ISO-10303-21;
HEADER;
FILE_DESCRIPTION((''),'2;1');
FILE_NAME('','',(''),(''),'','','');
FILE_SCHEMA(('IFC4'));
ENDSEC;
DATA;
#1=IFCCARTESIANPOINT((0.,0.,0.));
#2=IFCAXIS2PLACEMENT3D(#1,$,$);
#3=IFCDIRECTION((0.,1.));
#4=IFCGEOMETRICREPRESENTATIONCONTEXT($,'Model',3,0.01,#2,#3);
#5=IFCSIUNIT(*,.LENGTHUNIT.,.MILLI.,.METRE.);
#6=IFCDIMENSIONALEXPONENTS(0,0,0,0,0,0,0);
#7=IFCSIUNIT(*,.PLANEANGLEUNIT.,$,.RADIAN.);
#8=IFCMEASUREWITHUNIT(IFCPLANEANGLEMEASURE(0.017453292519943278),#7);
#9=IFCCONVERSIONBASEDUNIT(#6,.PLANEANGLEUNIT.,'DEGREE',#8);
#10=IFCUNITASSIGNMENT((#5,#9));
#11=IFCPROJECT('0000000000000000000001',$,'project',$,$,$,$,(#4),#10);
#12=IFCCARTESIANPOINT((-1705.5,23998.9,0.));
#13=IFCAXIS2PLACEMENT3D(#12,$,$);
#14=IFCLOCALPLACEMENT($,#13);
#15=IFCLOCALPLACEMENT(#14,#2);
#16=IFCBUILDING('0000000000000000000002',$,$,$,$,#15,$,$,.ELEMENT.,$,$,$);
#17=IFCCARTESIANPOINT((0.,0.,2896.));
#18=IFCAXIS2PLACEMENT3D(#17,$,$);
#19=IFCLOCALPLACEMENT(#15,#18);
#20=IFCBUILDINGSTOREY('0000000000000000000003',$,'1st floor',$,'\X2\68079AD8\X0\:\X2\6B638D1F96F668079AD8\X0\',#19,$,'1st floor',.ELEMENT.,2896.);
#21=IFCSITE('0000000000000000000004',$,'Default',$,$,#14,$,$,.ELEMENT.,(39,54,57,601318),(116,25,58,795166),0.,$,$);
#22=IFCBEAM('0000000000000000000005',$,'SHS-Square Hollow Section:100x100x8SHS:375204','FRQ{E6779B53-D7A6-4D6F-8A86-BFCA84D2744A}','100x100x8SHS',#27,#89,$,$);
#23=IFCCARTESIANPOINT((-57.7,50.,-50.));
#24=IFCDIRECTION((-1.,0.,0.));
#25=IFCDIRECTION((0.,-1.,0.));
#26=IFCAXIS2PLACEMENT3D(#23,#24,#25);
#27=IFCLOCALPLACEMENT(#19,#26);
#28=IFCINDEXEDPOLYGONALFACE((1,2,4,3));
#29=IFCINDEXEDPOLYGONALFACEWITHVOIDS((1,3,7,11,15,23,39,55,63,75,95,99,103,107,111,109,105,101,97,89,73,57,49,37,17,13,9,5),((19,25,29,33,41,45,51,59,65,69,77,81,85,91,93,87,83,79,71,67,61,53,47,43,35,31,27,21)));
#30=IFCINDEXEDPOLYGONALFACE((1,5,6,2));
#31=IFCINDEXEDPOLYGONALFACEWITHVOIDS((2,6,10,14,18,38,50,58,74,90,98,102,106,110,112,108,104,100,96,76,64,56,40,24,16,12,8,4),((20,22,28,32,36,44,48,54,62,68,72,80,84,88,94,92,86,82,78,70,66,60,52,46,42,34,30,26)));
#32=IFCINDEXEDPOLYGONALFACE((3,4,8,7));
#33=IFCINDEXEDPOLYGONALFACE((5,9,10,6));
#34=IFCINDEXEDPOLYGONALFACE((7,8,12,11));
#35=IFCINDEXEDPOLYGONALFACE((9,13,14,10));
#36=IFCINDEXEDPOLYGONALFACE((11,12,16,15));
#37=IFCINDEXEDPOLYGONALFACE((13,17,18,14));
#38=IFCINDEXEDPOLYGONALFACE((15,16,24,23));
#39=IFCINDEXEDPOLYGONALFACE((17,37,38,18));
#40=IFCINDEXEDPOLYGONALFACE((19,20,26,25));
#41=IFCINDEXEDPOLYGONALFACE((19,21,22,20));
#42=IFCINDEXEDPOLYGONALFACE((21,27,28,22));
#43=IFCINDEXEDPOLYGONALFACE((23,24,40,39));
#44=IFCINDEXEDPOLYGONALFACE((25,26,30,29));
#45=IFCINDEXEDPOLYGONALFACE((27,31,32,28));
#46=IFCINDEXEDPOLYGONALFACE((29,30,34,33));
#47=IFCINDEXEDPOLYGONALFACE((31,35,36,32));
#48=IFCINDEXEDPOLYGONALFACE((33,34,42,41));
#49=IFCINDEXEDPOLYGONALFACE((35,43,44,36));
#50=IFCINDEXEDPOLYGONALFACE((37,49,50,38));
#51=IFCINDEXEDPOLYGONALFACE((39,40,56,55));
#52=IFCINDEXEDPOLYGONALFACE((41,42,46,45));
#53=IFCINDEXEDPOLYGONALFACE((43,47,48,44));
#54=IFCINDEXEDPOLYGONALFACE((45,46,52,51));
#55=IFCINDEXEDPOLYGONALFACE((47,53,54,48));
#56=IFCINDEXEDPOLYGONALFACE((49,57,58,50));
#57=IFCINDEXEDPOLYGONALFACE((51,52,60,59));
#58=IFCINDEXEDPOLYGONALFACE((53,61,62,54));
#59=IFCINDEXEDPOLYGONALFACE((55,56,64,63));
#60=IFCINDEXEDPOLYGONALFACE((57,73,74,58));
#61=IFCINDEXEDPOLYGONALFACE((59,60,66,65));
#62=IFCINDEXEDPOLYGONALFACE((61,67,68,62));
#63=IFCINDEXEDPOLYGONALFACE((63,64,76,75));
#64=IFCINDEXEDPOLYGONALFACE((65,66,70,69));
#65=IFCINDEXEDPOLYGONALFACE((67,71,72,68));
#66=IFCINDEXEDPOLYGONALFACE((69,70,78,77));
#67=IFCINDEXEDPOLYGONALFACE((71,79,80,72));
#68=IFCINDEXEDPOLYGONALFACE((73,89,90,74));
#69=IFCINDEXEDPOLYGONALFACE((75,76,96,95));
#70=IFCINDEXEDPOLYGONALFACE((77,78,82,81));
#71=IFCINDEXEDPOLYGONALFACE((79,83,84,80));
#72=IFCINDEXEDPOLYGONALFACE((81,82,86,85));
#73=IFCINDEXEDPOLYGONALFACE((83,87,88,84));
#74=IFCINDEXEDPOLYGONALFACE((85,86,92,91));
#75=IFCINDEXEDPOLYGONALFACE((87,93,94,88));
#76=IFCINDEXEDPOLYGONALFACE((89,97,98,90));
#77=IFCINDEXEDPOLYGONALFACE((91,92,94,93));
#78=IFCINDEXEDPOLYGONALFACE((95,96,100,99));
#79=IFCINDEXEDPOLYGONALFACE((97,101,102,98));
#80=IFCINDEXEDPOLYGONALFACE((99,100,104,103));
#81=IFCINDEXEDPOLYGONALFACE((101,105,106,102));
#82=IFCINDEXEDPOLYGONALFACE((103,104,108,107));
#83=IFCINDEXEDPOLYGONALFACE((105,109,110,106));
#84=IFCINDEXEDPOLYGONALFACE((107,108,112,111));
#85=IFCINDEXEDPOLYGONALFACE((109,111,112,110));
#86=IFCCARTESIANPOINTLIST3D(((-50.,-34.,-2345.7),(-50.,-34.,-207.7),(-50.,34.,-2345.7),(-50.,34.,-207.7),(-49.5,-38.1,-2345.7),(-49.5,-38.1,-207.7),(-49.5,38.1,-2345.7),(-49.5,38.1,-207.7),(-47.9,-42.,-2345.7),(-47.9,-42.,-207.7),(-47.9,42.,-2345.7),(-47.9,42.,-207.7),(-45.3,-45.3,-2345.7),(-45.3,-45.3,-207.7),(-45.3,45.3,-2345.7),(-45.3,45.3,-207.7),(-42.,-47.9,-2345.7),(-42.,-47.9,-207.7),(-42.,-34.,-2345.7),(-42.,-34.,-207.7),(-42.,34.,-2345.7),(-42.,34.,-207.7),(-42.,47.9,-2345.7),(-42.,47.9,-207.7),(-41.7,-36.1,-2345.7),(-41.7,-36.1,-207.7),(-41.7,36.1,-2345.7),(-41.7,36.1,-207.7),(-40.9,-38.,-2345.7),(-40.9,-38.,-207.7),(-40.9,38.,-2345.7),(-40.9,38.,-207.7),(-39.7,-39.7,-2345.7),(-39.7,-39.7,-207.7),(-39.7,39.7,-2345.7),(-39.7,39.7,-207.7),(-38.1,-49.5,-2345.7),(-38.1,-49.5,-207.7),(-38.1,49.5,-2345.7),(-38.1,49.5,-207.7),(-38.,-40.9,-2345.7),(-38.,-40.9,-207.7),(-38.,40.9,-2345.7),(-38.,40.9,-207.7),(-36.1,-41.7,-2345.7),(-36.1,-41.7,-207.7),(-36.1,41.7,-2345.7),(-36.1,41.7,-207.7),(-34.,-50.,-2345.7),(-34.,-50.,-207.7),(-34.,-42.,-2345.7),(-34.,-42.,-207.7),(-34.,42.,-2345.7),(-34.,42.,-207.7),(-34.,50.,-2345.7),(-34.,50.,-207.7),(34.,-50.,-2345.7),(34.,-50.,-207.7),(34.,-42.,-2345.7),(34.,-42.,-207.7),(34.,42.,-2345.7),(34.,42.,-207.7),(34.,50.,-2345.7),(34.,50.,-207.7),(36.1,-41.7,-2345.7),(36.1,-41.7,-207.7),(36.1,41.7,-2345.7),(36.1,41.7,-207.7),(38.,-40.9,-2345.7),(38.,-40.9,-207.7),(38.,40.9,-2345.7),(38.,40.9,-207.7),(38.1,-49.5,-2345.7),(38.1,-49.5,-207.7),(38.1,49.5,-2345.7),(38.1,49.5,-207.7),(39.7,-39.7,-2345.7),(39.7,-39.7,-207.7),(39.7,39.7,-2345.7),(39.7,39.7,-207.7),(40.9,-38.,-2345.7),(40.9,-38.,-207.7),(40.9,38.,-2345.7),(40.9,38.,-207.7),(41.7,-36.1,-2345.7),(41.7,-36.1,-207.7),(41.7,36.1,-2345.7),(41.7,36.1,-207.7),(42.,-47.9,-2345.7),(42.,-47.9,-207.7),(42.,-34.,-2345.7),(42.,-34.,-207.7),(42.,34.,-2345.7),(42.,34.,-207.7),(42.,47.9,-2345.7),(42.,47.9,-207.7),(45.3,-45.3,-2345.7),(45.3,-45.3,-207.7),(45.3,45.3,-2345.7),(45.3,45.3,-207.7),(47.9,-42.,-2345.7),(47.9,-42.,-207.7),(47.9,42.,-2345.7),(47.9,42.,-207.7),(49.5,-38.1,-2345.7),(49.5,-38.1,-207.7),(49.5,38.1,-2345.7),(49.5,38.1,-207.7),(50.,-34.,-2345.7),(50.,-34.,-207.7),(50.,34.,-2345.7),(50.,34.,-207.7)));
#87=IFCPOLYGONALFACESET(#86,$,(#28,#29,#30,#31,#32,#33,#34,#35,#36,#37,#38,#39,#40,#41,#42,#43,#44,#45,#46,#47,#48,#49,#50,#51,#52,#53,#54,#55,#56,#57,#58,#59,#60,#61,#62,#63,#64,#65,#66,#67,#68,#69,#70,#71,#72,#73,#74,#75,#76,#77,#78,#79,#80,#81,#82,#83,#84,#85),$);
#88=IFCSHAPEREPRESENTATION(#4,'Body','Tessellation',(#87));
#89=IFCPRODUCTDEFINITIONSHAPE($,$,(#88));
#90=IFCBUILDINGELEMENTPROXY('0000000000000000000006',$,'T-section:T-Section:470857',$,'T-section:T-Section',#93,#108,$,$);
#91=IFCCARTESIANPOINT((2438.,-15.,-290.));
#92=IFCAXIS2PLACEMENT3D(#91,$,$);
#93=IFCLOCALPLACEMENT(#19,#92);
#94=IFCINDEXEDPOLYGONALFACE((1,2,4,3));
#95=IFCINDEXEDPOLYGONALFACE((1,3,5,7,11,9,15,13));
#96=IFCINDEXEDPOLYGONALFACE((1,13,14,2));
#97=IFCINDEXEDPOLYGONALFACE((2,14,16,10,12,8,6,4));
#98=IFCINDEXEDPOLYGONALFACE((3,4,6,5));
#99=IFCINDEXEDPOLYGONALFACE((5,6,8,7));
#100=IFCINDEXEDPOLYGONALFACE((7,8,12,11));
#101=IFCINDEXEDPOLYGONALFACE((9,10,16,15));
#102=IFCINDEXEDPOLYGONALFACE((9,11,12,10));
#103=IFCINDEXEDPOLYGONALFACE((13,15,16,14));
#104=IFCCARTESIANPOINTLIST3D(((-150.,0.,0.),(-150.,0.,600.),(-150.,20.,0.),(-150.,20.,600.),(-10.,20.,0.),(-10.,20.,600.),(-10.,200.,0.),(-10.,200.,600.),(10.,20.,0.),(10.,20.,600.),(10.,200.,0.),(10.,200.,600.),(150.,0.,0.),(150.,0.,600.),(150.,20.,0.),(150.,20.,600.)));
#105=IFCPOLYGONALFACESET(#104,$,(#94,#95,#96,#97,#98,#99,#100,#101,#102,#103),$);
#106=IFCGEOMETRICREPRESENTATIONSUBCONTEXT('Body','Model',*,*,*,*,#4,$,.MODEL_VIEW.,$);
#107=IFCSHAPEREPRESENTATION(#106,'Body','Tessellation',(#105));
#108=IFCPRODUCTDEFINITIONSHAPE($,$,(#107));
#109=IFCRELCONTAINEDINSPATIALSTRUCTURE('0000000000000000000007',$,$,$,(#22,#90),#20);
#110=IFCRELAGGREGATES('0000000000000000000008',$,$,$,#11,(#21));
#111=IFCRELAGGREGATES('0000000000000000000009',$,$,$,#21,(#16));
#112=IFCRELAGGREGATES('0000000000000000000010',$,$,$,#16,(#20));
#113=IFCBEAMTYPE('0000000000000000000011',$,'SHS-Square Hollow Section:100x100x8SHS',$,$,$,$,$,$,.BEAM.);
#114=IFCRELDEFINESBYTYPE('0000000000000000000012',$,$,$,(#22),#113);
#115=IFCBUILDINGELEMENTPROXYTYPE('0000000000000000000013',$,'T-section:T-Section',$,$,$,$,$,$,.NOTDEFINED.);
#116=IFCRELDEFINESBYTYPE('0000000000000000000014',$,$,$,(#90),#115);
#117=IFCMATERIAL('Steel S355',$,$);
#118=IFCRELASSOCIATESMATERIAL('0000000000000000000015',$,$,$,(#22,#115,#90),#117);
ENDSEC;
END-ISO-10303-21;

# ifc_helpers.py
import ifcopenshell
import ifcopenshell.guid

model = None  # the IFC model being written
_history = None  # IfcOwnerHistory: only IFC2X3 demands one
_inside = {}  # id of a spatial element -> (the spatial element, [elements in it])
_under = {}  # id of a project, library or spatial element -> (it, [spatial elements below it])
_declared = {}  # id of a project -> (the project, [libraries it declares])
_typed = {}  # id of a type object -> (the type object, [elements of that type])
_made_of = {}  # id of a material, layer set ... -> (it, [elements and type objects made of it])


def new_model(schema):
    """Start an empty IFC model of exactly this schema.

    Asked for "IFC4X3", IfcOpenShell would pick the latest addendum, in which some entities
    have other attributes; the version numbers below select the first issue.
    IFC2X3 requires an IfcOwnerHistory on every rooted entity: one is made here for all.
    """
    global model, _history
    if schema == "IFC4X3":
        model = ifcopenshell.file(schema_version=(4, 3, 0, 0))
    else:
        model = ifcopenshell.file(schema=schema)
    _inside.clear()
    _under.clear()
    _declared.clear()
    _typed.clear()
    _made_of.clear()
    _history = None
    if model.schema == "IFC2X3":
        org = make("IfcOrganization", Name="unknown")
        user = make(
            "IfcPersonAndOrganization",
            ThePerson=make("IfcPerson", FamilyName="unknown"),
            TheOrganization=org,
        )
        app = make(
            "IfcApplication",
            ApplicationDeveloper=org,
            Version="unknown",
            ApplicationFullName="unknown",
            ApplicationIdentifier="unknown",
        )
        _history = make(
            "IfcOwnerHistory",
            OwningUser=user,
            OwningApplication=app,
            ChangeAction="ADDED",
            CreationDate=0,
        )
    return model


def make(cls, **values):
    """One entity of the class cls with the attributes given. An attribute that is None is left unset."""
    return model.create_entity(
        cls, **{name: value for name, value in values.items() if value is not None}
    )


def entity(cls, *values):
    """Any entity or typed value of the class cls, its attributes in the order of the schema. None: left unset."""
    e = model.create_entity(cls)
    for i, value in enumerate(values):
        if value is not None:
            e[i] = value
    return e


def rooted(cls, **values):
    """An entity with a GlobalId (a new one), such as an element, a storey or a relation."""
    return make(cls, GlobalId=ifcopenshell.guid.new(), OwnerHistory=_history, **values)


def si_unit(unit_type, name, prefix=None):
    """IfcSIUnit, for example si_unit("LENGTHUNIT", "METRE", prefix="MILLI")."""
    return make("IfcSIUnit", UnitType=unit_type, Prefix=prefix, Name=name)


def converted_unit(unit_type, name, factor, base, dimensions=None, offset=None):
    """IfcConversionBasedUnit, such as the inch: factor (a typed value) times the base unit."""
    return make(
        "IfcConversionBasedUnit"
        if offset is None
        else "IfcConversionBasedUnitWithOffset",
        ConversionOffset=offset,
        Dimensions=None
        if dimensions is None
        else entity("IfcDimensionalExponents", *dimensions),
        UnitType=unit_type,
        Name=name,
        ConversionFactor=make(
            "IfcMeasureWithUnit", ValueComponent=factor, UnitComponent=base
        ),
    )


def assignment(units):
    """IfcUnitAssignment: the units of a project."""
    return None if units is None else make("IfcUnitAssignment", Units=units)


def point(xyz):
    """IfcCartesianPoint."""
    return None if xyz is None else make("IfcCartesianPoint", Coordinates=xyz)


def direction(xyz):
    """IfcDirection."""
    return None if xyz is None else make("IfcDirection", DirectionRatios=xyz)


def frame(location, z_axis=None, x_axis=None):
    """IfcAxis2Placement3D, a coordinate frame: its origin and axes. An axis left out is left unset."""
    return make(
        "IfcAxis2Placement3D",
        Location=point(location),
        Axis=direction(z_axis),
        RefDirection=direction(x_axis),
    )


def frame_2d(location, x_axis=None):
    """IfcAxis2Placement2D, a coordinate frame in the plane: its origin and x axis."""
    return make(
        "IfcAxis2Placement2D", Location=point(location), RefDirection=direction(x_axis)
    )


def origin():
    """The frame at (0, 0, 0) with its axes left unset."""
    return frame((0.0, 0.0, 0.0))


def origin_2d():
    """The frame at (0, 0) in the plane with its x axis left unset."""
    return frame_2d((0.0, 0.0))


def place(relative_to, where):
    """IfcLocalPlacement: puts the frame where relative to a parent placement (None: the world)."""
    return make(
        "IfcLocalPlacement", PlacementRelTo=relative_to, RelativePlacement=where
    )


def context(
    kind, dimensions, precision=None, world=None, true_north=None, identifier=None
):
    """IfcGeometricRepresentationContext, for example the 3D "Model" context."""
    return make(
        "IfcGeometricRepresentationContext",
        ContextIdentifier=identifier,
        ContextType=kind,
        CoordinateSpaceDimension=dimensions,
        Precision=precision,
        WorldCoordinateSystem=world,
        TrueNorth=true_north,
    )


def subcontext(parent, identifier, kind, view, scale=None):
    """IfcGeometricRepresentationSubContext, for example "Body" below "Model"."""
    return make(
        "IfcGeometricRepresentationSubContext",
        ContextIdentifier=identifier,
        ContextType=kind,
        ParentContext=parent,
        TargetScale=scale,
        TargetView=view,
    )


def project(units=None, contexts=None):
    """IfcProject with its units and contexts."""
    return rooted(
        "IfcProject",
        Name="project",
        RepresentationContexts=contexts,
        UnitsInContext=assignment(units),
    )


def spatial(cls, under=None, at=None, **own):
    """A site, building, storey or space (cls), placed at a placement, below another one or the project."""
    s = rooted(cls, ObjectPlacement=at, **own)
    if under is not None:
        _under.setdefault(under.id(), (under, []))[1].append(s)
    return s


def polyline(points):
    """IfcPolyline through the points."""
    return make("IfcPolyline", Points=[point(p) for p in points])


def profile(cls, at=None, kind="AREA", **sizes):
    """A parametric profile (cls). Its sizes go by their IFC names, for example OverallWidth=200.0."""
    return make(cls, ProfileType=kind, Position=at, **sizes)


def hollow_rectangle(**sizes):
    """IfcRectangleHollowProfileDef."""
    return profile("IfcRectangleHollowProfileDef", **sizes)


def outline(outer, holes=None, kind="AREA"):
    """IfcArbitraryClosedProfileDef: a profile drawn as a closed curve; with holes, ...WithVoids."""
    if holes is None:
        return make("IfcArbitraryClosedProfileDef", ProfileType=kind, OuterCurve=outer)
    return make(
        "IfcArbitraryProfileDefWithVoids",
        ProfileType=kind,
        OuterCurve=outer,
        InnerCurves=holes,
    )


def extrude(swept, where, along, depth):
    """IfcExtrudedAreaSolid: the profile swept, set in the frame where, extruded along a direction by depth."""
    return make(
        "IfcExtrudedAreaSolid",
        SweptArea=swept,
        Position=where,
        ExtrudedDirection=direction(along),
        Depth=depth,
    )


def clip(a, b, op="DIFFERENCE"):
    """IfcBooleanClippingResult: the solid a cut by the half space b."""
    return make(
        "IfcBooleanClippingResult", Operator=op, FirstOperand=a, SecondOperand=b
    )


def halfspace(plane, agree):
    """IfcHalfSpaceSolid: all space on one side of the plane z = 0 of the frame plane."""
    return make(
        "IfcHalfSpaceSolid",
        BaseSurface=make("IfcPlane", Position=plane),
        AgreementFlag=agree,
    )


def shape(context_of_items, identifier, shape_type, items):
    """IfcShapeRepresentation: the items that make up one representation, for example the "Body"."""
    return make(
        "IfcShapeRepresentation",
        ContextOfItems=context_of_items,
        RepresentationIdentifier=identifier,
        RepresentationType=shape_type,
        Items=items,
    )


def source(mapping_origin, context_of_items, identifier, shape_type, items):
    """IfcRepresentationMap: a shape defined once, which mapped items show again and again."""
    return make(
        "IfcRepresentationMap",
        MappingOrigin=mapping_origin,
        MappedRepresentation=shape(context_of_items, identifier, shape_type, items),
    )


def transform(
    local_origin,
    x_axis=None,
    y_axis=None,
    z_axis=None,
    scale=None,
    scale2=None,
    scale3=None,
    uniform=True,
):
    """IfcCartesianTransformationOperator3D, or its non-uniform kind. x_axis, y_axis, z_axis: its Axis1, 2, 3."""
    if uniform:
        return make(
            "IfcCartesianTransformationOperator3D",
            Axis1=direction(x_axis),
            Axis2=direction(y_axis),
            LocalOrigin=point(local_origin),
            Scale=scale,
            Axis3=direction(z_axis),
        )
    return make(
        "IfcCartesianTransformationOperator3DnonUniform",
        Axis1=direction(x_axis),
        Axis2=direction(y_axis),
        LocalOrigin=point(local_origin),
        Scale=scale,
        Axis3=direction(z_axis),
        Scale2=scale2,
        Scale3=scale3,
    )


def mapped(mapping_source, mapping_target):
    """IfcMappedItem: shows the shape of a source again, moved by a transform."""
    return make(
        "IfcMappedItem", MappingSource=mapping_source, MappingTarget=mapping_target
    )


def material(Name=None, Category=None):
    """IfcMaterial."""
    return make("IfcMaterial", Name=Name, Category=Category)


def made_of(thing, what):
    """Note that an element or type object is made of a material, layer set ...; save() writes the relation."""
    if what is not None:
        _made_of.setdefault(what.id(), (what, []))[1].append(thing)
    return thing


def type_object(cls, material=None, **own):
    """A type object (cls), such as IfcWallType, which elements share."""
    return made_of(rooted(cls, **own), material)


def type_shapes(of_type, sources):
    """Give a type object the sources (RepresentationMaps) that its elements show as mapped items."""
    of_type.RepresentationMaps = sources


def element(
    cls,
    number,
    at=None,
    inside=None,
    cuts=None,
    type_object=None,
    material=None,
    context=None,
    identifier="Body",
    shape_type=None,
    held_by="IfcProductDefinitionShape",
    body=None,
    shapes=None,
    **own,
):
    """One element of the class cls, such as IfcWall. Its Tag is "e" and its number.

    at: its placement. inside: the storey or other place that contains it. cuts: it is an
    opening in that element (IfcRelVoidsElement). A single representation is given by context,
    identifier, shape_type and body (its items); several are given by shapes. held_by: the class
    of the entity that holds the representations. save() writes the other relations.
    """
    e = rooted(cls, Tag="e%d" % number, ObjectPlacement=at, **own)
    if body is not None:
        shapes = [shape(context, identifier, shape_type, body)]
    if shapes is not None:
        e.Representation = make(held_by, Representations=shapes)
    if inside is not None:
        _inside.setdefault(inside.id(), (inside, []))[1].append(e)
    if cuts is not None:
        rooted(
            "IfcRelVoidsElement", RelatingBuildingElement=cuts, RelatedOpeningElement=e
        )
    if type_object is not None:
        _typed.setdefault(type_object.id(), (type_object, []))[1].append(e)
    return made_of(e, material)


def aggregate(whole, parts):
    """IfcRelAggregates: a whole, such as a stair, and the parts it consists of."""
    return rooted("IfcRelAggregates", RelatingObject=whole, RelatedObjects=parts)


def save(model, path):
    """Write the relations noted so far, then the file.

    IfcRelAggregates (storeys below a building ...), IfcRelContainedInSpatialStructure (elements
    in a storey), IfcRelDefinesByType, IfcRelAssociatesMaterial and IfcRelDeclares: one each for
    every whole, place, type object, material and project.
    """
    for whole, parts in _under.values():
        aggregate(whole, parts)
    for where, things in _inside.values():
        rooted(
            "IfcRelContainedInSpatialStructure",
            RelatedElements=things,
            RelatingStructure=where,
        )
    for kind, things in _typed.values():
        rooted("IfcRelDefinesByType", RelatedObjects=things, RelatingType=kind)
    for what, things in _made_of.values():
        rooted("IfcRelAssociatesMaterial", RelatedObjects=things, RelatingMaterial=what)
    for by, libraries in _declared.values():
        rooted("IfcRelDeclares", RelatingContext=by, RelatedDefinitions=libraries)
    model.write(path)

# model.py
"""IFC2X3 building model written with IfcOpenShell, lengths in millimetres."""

from ifc_helpers import new_model, entity, si_unit, converted_unit, direction, frame, origin, origin_2d, place, context, subcontext, project, spatial, polyline, hollow_rectangle, outline, extrude, clip, halfspace, source, transform, mapped, material, type_object, type_shapes, element, save


model = new_model("IFC2X3")

# Units and contexts
model_context = context("Model", 3, precision=0.01, world=origin(), true_north=direction((0.0, 1.0)))
body_context = subcontext(model_context, "Body", "Model", "MODEL_VIEW")
ifc_project = project(units=[si_unit("LENGTHUNIT", "METRE", prefix="MILLI"), converted_unit("PLANEANGLEUNIT", "DEGREE", entity("IfcPlaneAngleMeasure", 0.017453292519943278), si_unit("PLANEANGLEUNIT", "RADIAN"), dimensions=[0, 0, 0, 0, 0, 0, 0])], contexts=[model_context])

# Site, building, storey
site_placement = place(None, frame((-1705.5, 23998.9, 0.0)))
site = spatial("IfcSite", under=ifc_project, at=site_placement, Name="Default", CompositionType="ELEMENT", RefLatitude=(39, 54, 57, 601318), RefLongitude=(116, 25, 58, 795166), RefElevation=0.0)
building_placement = place(site_placement, origin())
building = spatial("IfcBuilding", under=site, at=building_placement, CompositionType="ELEMENT")
storey_placement = place(building_placement, frame((0.0, 0.0, 2896.0)))
storey = spatial("IfcBuildingStorey", under=building, at=storey_placement, Name="1st floor", ObjectType="标高:正负零标高", LongName="1st floor", CompositionType="ELEMENT", Elevation=2896.0)

# Shared definitions
ifc_material_1 = material(Name="Steel S355")

# Beam
beam_type_1 = type_object("IfcBeamType", Name="SHS-Square Hollow Section:100x100x8SHS", PredefinedType="BEAM")
beam_1_placement = place(storey_placement, frame((-57.7, 50.0, -50.0), z_axis=(-1.0, 0.0, 0.0), x_axis=(0.0, -1.0, 0.0)))
element("IfcBeam", 1, at=beam_1_placement, inside=storey, type_object=beam_type_1, material=ifc_material_1, Name="SHS-Square Hollow Section:100x100x8SHS:375204", Description="FRQ{E6779B53-D7A6-4D6F-8A86-BFCA84D2744A}", ObjectType="100x100x8SHS", context=model_context, shape_type="Clipping", body=[
    clip(clip(extrude(hollow_rectangle(XDim=100.0, YDim=100.0, WallThickness=8.0, InnerFilletRadius=8.0, OuterFilletRadius=16.0, at=origin_2d()), origin(), (0.0, 0.0, -1.0), 2551.4), halfspace(frame((50.0, -2846.0, -2345.7), z_axis=(0.0, 0.0, 1.0), x_axis=(1.0, 0.0, 0.0)), True)), halfspace(frame((50.0, -2846.0, -207.7), z_axis=(0.0, 0.0, -1.0), x_axis=(-1.0, 0.0, 0.0)), True)),
])

# Building element proxy
building_element_proxy_type_1 = type_object("IfcBuildingElementProxyType", Name="T-section:T-Section", PredefinedType="NOTDEFINED", material=ifc_material_1)
shared_shape_1 = source(origin(), body_context, "Body", "SweptSolid", [
    extrude(outline(polyline([(-140.0, 10.0), (-140.0, -10.0), (40.0, -10.0), (40.0, -150.0), (60.0, -150.0), (60.0, 150.0), (40.0, 150.0), (40.0, 10.0), (-140.0, 10.0)])), frame((0.0, 60.0, 0.0), z_axis=(0.0, 0.0, -1.0), x_axis=(0.0, -1.0, 0.0)), (0.0, 0.0, -1.0), 600.0),
])
type_shapes(building_element_proxy_type_1, [shared_shape_1])
proxy_placement = place(storey_placement, frame((2438.0, -15.0, -290.0)))
element("IfcBuildingElementProxy", 2, at=proxy_placement, inside=storey, type_object=building_element_proxy_type_1, material=ifc_material_1, Name="T-section:T-Section:470857", ObjectType="T-section:T-Section", context=body_context, shape_type="MappedRepresentation", body=[
    mapped(shared_shape_1, transform((0.0, 0.0, 0.0), scale=1.0)),
])

save(model, "model.ifc")
